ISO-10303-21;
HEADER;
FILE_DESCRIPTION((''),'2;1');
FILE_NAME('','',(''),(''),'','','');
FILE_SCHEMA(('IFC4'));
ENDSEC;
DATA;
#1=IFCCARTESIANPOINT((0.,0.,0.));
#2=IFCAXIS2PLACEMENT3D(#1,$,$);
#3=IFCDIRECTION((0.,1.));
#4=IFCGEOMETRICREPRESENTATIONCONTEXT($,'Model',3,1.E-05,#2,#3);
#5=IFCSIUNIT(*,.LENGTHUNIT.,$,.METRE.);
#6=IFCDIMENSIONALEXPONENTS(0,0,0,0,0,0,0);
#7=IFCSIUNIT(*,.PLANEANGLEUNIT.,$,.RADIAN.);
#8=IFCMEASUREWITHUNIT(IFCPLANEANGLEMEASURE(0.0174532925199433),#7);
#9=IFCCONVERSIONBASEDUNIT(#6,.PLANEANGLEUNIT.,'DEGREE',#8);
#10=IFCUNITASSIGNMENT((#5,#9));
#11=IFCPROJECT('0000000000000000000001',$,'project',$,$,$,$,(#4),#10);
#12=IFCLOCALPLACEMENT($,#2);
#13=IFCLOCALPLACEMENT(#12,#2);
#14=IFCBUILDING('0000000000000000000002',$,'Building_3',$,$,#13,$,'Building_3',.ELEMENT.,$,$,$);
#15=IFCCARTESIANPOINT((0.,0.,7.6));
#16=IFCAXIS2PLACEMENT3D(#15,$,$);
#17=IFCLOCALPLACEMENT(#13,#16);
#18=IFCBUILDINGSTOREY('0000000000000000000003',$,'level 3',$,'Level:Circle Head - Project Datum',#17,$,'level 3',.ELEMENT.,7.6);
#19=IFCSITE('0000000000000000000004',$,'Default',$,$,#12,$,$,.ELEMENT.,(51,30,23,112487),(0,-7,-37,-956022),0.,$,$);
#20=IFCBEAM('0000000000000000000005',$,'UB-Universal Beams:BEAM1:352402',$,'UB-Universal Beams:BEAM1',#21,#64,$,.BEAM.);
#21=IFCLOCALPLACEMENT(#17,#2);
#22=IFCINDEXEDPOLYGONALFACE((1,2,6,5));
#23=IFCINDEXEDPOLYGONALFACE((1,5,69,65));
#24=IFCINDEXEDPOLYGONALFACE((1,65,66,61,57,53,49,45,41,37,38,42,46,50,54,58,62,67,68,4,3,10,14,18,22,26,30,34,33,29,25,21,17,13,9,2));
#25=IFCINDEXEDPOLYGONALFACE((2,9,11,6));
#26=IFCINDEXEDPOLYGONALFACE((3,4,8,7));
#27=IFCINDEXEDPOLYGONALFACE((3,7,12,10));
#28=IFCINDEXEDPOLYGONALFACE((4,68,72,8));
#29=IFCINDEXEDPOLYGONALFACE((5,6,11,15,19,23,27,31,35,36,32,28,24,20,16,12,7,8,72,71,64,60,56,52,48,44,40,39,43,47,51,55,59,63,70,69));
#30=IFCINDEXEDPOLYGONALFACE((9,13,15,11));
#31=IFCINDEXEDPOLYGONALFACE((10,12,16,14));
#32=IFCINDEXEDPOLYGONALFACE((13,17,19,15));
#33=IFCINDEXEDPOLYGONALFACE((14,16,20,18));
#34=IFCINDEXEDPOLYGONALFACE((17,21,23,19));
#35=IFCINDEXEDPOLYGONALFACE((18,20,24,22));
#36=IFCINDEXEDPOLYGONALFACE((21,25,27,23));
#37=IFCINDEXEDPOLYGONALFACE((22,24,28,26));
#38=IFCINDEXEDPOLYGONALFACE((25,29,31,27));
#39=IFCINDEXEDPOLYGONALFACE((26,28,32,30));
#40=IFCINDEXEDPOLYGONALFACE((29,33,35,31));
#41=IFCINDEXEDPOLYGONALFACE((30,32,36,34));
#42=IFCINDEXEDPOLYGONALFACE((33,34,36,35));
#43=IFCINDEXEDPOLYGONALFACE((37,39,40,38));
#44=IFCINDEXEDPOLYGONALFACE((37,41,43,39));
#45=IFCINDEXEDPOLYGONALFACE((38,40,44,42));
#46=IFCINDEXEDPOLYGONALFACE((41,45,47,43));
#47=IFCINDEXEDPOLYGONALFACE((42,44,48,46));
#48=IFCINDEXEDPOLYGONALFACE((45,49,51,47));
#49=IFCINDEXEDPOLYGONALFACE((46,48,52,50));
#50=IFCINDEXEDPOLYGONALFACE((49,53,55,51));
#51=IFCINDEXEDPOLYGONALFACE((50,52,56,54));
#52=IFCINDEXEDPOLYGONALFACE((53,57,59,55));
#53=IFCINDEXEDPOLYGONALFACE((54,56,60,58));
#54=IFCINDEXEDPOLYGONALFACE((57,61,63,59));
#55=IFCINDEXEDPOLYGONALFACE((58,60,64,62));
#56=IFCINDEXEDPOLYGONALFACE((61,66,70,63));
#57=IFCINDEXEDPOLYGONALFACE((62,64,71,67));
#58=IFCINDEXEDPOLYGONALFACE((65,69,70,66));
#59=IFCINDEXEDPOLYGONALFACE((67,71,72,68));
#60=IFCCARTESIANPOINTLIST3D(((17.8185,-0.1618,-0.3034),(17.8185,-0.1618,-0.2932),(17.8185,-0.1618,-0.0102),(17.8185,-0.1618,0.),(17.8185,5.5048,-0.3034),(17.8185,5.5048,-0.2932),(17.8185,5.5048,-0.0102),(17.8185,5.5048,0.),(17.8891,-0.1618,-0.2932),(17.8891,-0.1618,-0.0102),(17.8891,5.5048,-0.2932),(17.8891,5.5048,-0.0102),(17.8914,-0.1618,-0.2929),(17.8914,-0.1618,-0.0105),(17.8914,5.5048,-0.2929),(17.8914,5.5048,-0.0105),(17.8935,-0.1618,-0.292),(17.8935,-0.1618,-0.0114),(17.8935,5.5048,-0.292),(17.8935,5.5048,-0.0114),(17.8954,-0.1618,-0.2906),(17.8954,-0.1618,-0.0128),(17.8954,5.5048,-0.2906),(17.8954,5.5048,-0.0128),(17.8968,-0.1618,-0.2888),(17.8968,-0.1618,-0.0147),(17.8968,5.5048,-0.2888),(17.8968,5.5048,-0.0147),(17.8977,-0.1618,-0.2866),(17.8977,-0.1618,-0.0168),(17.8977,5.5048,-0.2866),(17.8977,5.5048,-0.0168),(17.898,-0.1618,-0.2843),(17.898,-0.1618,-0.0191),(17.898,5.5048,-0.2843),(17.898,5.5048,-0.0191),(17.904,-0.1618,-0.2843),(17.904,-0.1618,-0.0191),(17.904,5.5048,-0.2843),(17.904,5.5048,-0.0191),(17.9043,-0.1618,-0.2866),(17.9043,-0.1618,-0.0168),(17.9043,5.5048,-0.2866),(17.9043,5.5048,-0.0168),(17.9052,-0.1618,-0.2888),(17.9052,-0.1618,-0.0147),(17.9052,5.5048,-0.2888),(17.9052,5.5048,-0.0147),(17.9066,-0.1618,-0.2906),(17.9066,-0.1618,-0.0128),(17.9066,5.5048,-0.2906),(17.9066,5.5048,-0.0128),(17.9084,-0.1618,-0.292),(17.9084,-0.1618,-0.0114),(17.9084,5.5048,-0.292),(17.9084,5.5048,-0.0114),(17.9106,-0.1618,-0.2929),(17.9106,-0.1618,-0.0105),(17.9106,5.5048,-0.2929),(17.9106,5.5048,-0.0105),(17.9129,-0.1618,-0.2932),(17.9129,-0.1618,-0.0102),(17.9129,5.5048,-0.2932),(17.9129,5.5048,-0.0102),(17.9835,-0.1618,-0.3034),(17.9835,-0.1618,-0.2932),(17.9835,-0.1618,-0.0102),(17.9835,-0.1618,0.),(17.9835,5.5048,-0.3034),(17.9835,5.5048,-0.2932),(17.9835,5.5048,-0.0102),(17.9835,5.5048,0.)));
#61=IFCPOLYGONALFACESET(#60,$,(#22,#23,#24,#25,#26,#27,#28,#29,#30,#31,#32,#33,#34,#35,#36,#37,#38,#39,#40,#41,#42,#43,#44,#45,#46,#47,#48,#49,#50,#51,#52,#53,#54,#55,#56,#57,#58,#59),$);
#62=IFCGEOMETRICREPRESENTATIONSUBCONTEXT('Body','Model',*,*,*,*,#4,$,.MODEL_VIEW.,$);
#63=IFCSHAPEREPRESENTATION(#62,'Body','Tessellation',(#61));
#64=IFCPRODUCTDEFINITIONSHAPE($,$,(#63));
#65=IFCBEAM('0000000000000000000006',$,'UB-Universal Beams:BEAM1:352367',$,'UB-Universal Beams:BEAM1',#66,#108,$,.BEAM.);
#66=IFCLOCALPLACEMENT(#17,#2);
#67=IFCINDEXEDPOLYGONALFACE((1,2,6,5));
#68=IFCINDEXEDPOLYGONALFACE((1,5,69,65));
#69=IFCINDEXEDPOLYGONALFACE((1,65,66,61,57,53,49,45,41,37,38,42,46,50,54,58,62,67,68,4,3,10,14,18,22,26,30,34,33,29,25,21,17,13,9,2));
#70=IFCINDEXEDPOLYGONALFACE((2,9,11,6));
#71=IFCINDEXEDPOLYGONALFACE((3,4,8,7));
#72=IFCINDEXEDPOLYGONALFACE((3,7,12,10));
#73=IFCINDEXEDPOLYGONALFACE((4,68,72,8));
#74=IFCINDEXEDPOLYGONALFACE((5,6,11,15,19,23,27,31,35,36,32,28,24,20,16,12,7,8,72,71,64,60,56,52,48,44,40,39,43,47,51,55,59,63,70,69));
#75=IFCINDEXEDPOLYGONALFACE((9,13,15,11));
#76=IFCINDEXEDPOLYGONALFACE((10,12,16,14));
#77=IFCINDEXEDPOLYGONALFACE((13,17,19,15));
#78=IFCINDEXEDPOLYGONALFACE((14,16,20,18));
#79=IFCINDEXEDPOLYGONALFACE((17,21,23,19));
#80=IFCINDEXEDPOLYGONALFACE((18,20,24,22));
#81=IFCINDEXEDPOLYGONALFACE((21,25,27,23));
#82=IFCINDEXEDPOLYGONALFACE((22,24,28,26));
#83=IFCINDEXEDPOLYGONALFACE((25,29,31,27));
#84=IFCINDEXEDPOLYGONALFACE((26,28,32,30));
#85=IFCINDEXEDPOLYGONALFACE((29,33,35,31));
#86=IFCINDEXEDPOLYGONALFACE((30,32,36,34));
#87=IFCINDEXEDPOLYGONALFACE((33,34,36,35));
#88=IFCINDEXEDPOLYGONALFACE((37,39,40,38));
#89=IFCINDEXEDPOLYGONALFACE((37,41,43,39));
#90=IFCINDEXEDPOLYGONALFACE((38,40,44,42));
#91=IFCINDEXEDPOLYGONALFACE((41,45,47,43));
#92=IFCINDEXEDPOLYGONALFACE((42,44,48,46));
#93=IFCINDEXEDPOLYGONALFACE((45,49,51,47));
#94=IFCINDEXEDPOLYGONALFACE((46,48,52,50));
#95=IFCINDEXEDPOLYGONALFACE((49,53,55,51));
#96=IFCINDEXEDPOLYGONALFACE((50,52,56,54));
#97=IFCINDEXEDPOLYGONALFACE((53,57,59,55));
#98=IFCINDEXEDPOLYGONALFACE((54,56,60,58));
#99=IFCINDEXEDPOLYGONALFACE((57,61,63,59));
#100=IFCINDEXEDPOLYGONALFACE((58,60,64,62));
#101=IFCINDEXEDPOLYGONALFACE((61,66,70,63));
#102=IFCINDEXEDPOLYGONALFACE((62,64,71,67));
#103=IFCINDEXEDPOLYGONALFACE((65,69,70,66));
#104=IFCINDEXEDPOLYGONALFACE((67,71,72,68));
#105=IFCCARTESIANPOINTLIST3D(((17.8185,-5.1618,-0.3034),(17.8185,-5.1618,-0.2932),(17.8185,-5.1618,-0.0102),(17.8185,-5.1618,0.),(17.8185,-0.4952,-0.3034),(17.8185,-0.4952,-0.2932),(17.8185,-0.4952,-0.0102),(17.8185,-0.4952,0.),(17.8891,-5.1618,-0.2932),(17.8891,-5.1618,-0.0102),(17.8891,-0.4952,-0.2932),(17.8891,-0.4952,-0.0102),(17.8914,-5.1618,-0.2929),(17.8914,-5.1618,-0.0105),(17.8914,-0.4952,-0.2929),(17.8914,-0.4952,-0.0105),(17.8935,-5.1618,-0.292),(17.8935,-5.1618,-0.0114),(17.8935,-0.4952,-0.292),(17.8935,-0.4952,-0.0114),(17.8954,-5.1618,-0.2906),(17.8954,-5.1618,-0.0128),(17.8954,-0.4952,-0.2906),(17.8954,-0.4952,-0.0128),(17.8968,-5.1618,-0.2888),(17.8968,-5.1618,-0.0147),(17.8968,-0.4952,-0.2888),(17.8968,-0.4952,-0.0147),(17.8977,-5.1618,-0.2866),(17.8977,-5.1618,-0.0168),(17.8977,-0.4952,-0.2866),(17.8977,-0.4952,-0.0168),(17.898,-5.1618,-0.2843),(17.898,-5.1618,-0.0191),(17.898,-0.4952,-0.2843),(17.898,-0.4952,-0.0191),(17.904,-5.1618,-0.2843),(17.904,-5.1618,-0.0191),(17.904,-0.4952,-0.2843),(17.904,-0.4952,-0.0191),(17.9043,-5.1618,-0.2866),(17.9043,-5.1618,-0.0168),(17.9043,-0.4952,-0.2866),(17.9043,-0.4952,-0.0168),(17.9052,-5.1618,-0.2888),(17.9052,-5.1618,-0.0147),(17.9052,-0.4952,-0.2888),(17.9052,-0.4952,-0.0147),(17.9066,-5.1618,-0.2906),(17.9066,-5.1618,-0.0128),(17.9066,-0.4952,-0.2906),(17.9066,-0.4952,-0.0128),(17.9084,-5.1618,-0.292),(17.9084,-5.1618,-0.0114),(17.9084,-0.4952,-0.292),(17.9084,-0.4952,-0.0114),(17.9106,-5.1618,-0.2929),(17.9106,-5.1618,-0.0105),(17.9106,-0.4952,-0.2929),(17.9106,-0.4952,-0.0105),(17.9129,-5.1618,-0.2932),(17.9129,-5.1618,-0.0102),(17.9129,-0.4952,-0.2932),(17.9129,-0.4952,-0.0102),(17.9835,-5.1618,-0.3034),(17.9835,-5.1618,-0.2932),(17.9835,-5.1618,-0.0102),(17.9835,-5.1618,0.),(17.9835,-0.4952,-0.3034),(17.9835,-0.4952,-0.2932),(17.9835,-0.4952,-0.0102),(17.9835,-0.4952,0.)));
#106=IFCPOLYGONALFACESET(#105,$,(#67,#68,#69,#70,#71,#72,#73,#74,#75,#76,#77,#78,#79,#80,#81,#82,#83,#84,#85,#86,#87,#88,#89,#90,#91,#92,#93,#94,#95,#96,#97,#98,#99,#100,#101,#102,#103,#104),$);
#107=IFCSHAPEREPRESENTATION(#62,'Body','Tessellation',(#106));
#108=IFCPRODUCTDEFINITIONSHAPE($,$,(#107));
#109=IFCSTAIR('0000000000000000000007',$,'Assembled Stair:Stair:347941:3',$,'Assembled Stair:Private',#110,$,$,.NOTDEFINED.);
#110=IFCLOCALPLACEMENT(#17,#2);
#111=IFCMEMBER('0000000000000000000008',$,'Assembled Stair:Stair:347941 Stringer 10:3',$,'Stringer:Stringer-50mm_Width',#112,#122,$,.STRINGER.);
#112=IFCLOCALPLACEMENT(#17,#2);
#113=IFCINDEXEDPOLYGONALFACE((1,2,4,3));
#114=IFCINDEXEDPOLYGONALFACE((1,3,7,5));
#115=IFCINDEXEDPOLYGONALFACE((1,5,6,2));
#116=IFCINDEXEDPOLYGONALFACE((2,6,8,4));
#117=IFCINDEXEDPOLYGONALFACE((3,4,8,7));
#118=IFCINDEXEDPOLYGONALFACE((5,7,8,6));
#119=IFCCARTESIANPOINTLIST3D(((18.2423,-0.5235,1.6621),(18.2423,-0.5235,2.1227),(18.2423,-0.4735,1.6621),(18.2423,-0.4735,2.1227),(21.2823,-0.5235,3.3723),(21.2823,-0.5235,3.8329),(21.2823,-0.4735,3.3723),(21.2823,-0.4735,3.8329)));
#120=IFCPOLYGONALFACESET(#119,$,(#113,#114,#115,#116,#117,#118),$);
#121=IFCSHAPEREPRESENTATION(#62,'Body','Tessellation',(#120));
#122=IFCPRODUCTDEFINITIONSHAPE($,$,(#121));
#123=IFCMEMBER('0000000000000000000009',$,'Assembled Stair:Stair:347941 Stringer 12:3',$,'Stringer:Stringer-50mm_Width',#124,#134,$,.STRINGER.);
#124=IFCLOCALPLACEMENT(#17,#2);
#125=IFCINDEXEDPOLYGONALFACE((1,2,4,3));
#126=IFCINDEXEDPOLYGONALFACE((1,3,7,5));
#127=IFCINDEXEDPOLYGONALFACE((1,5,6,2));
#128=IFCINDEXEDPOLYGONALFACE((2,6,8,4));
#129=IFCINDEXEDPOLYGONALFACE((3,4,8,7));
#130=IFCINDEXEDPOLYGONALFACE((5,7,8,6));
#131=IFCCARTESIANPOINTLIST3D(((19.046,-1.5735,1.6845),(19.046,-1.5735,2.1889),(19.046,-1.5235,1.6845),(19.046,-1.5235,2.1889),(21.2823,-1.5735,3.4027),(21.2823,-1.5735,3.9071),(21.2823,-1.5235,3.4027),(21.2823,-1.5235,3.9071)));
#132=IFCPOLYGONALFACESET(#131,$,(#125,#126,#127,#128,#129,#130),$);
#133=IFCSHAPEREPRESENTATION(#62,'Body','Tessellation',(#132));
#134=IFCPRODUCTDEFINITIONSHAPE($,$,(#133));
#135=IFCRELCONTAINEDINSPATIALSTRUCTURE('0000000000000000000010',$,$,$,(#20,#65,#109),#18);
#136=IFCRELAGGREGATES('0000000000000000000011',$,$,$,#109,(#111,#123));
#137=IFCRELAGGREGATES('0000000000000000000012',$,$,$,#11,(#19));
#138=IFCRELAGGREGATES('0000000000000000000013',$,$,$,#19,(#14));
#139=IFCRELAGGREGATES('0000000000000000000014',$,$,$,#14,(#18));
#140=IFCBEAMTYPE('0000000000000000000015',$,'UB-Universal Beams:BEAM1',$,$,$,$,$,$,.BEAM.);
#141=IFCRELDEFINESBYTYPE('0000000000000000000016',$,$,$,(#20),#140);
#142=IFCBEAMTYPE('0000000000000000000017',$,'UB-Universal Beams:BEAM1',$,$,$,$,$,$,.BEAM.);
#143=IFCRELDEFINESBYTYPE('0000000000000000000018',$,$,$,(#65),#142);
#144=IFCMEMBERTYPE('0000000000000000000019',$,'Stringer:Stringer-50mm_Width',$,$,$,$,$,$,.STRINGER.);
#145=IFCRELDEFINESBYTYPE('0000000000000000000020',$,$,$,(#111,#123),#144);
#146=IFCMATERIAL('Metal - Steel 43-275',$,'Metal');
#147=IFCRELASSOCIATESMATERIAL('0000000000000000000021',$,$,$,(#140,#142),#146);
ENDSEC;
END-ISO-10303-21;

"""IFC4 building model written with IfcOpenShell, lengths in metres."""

from ifc_helpers import new_model, entity, si_unit, converted_unit, direction, frame, frame_2d, origin, place, context, subcontext, project, spatial, polyline, circle_curve, parameter, trimmed, segment, composite_curve, outline, extrude, source, transform, mapped, material, material_profile, profile_set, type_object, type_shapes, element, aggregate, save


model = new_model("IFC4")

# Units and contexts
model_context = context("Model", 3, precision=1e-05, world=origin(), true_north=direction((0.0, 1.0)))
body_context = subcontext(model_context, "Body", "Model", "MODEL_VIEW")
ifc_project = project(units=[si_unit("LENGTHUNIT", "METRE"), converted_unit("PLANEANGLEUNIT", "DEGREE", entity("IfcPlaneAngleMeasure", 0.0174532925199433), si_unit("PLANEANGLEUNIT", "RADIAN"), dimensions=[0, 0, 0, 0, 0, 0, 0])], contexts=[model_context])

# Site, building, storey
site_placement = place(None, origin())
site = spatial("IfcSite", under=ifc_project, at=site_placement, Name="Default", CompositionType="ELEMENT", RefLatitude=(51, 30, 23, 112487), RefLongitude=(0, -7, -37, -956022), RefElevation=0.0)
building_placement = place(site_placement, origin())
building = spatial("IfcBuilding", under=site, at=building_placement, Name="Building_3", LongName="Building_3", CompositionType="ELEMENT")
storey_placement = place(building_placement, frame((0.0, 0.0, 7.6)))
storey = spatial("IfcBuildingStorey", under=building, at=storey_placement, Name="level 3", ObjectType="Level:Circle Head - Project Datum", LongName="level 3", CompositionType="ELEMENT", Elevation=7.6)

# Beams
ifc_material_1 = material(Name="Metal - Steel 43-275", Category="Metal")
ifc_material_profile = material_profile(ifc_material_1, outline(composite_curve([segment(polyline([(-0.0825, -0.1415), (-0.0825, -0.1517)]), True, "CONTINUOUS"), segment(polyline([(-0.0825, -0.1517), (0.0825, -0.1517)]), True, "CONTINUOUS"), segment(polyline([(0.0825, -0.1517), (0.0825, -0.1415)]), True, "CONTINUOUS"), segment(polyline([(0.0825, -0.1415), (0.0119, -0.1415)]), True, "CONTINUOUS"), segment(trimmed(circle_curve(frame_2d((0.0119, -0.1326), x_axis=(1.0, 0.0)), 0.0089), [parameter(180.0)], [parameter(270.0)], True, "PARAMETER"), False, "CONTINUOUS"), segment(polyline([(0.003, -0.1326), (0.003, 0.1326)]), True, "CONTINUOUS"), segment(trimmed(circle_curve(frame_2d((0.0119, 0.1326), x_axis=(1.0, 0.0)), 0.0089), [parameter(90.0)], [parameter(180.0)], True, "PARAMETER"), False, "CONTINUOUS"), segment(polyline([(0.0119, 0.1415), (0.0825, 0.1415)]), True, "CONTINUOUS"), segment(polyline([(0.0825, 0.1415), (0.0825, 0.1517)]), True, "CONTINUOUS"), segment(polyline([(0.0825, 0.1517), (-0.0825, 0.1517)]), True, "CONTINUOUS"), segment(polyline([(-0.0825, 0.1517), (-0.0825, 0.1415)]), True, "CONTINUOUS"), segment(polyline([(-0.0825, 0.1415), (-0.0119, 0.1415)]), True, "CONTINUOUS"), segment(trimmed(circle_curve(frame_2d((-0.0119, 0.1326), x_axis=(1.0, 0.0)), 0.0089), [parameter(360.0)], [parameter(90.0)], True, "PARAMETER"), False, "CONTINUOUS"), segment(polyline([(-0.003, 0.1326), (-0.003, -0.1326)]), True, "CONTINUOUS"), segment(trimmed(circle_curve(frame_2d((-0.0119, -0.1326), x_axis=(1.0, 0.0)), 0.0089), [parameter(270.0)], [parameter(360.0)], True, "PARAMETER"), False, "CONTINUOUS"), segment(polyline([(-0.0119, -0.1415), (-0.0825, -0.1415)]), True, "CONTINUOUS")], self_intersect=False)), Name="BEAM1")
ifc_profile_set = profile_set([ifc_material_profile], Name="BEAM1")
beam_type_1 = type_object("IfcBeamType", Name="UB-Universal Beams:BEAM1", PredefinedType="BEAM", material=ifc_profile_set)
shared_shape_1 = source(origin(), body_context, "Body", "SweptSolid", [
    extrude(outline(composite_curve([segment(polyline([(-0.0825, -0.1415), (-0.0825, -0.1517)]), True, "CONTINUOUS"), segment(polyline([(-0.0825, -0.1517), (0.0825, -0.1517)]), True, "CONTINUOUS"), segment(polyline([(0.0825, -0.1517), (0.0825, -0.1415)]), True, "CONTINUOUS"), segment(polyline([(0.0825, -0.1415), (0.0119, -0.1415)]), True, "CONTINUOUS"), segment(trimmed(circle_curve(frame_2d((0.0119, -0.1326), x_axis=(1.0, 0.0)), 0.0089), [parameter(180.0)], [parameter(270.0)], True, "PARAMETER"), False, "CONTINUOUS"), segment(polyline([(0.003, -0.1326), (0.003, 0.1326)]), True, "CONTINUOUS"), segment(trimmed(circle_curve(frame_2d((0.0119, 0.1326), x_axis=(1.0, 0.0)), 0.0089), [parameter(90.0)], [parameter(180.0)], True, "PARAMETER"), False, "CONTINUOUS"), segment(polyline([(0.0119, 0.1415), (0.0825, 0.1415)]), True, "CONTINUOUS"), segment(polyline([(0.0825, 0.1415), (0.0825, 0.1517)]), True, "CONTINUOUS"), segment(polyline([(0.0825, 0.1517), (-0.0825, 0.1517)]), True, "CONTINUOUS"), segment(polyline([(-0.0825, 0.1517), (-0.0825, 0.1415)]), True, "CONTINUOUS"), segment(polyline([(-0.0825, 0.1415), (-0.0119, 0.1415)]), True, "CONTINUOUS"), segment(trimmed(circle_curve(frame_2d((-0.0119, 0.1326), x_axis=(1.0, 0.0)), 0.0089), [parameter(360.0)], [parameter(90.0)], True, "PARAMETER"), False, "CONTINUOUS"), segment(polyline([(-0.003, 0.1326), (-0.003, -0.1326)]), True, "CONTINUOUS"), segment(trimmed(circle_curve(frame_2d((-0.0119, -0.1326), x_axis=(1.0, 0.0)), 0.0089), [parameter(270.0)], [parameter(360.0)], True, "PARAMETER"), False, "CONTINUOUS"), segment(polyline([(-0.0119, -0.1415), (-0.0825, -0.1415)]), True, "CONTINUOUS")], self_intersect=False)), frame((-2.8333, 0.0, 0.0), z_axis=(-1.0, 0.0, 0.0), x_axis=(0.0, -1.0, 0.0)), (0.0, 0.0, -1.0), 5.6666),
])
type_shapes(beam_type_1, [shared_shape_1])
for number, where, z_axis, x_axis, name in (
    (1, (17.901, 2.6715, -0.1517), (0.0, 0.0, 1.0), (0.0, -1.0, 0.0), "UB-Universal Beams:BEAM1:352402"),
):
    element("IfcBeam", number, at=place(storey_placement, frame(where, z_axis=z_axis, x_axis=x_axis)), inside=storey, type_object=beam_type_1, Name=name, ObjectType="UB-Universal Beams:BEAM1", PredefinedType="BEAM", context=body_context, shape_type="MappedRepresentation", body=[
        mapped(shared_shape_1, transform((0.0, 0.0, 0.0), scale=1.0)),
    ])
beam_type_2 = type_object("IfcBeamType", Name="UB-Universal Beams:BEAM1", PredefinedType="BEAM", material=ifc_profile_set)
shared_shape_2 = source(origin(), body_context, "Body", "SweptSolid", [
    extrude(outline(composite_curve([segment(polyline([(-0.0825, -0.1415), (-0.0825, -0.1517)]), True, "CONTINUOUS"), segment(polyline([(-0.0825, -0.1517), (0.0825, -0.1517)]), True, "CONTINUOUS"), segment(polyline([(0.0825, -0.1517), (0.0825, -0.1415)]), True, "CONTINUOUS"), segment(polyline([(0.0825, -0.1415), (0.0119, -0.1415)]), True, "CONTINUOUS"), segment(trimmed(circle_curve(frame_2d((0.0119, -0.1326), x_axis=(0.0, -1.0)), 0.0089), [parameter(270.0)], [parameter(360.0)], True, "PARAMETER"), False, "CONTINUOUS"), segment(polyline([(0.003, -0.1326), (0.003, 0.1326)]), True, "CONTINUOUS"), segment(trimmed(circle_curve(frame_2d((0.0119, 0.1326), x_axis=(-1.0, 0.0)), 0.0089), [parameter(270.0)], [parameter(360.0)], True, "PARAMETER"), False, "CONTINUOUS"), segment(polyline([(0.0119, 0.1415), (0.0825, 0.1415)]), True, "CONTINUOUS"), segment(polyline([(0.0825, 0.1415), (0.0825, 0.1517)]), True, "CONTINUOUS"), segment(polyline([(0.0825, 0.1517), (-0.0825, 0.1517)]), True, "CONTINUOUS"), segment(polyline([(-0.0825, 0.1517), (-0.0825, 0.1415)]), True, "CONTINUOUS"), segment(polyline([(-0.0825, 0.1415), (-0.0119, 0.1415)]), True, "CONTINUOUS"), segment(trimmed(circle_curve(frame_2d((-0.0119, 0.1326), x_axis=(0.0, 1.0)), 0.0089), [parameter(270.0)], [parameter(360.0)], True, "PARAMETER"), False, "CONTINUOUS"), segment(polyline([(-0.003, 0.1326), (-0.003, -0.1326)]), True, "CONTINUOUS"), segment(trimmed(circle_curve(frame_2d((-0.0119, -0.1326), x_axis=(1.0, 0.0)), 0.0089), [parameter(270.0)], [parameter(0.0)], True, "PARAMETER"), False, "CONTINUOUS"), segment(polyline([(-0.0119, -0.1415), (-0.0825, -0.1415)]), True, "CONTINUOUS")], self_intersect=False)), frame((-2.3333, 0.0, 0.0), z_axis=(-1.0, 0.0, 0.0), x_axis=(0.0, -1.0, 0.0)), (0.0, 0.0, -1.0), 4.6666),
])
type_shapes(beam_type_2, [shared_shape_2])
beam_placement = place(storey_placement, frame((17.901, -2.8285, -0.1517), z_axis=(0.0, 0.0, 1.0), x_axis=(0.0, -1.0, 0.0)))
element("IfcBeam", 2, at=beam_placement, inside=storey, type_object=beam_type_2, Name="UB-Universal Beams:BEAM1:352367", ObjectType="UB-Universal Beams:BEAM1", PredefinedType="BEAM", context=body_context, shape_type="MappedRepresentation", body=[
    mapped(shared_shape_2, transform((0.0, 0.0, 0.0), scale=1.0)),
])

# Stair, members
stair_placement = place(storey_placement, origin())
stair = element("IfcStair", 3, at=stair_placement, inside=storey, Name="Assembled Stair:Stair:347941:3", ObjectType="Assembled Stair:Private", PredefinedType="NOTDEFINED")
member_type = type_object("IfcMemberType", Name="Stringer:Stringer-50mm_Width", PredefinedType="STRINGER")
member_1_placement = place(stair_placement, frame((18.2423, -0.5235, 1.6621)))
member_1 = element("IfcMember", 4, at=member_1_placement, type_object=member_type, Name="Assembled Stair:Stair:347941 Stringer 10:3", ObjectType="Stringer:Stringer-50mm_Width", PredefinedType="STRINGER", context=body_context, shape_type="SweptSolid", body=[
    extrude(outline(polyline([(-1.6311, -0.2007), (1.857, -0.2007), (1.6311, 0.2007), (-1.857, 0.2007), (-1.6311, -0.2007)])), frame((1.52, 0.0, 1.0854), z_axis=(0.0, 1.0, 0.0), x_axis=(0.871553, 0.0, 0.490302)), (0.0, 0.0, 1.0), 0.05),
])
member_2_placement = place(stair_placement, frame((19.046, -1.5735, 1.6845)))
member_2 = element("IfcMember", 5, at=member_2_placement, type_object=member_type, Name="Assembled Stair:Stair:347941 Stringer 12:3", ObjectType="Stringer:Stringer-50mm_Width", PredefinedType="STRINGER", context=body_context, shape_type="SweptSolid", body=[
    extrude(outline(polyline([(-1.2564, -0.2), (1.5637, -0.2), (1.2564, 0.2), (-1.5637, 0.2), (-1.2564, -0.2)])), frame((1.1182, 0.0, 1.1113), z_axis=(0.0, 1.0, 0.0), x_axis=(0.792984, 0.0, 0.609242)), (0.0, 0.0, 1.0), 0.05),
])
aggregate(stair, [member_1, member_2])

save(model, "model.ifc")
